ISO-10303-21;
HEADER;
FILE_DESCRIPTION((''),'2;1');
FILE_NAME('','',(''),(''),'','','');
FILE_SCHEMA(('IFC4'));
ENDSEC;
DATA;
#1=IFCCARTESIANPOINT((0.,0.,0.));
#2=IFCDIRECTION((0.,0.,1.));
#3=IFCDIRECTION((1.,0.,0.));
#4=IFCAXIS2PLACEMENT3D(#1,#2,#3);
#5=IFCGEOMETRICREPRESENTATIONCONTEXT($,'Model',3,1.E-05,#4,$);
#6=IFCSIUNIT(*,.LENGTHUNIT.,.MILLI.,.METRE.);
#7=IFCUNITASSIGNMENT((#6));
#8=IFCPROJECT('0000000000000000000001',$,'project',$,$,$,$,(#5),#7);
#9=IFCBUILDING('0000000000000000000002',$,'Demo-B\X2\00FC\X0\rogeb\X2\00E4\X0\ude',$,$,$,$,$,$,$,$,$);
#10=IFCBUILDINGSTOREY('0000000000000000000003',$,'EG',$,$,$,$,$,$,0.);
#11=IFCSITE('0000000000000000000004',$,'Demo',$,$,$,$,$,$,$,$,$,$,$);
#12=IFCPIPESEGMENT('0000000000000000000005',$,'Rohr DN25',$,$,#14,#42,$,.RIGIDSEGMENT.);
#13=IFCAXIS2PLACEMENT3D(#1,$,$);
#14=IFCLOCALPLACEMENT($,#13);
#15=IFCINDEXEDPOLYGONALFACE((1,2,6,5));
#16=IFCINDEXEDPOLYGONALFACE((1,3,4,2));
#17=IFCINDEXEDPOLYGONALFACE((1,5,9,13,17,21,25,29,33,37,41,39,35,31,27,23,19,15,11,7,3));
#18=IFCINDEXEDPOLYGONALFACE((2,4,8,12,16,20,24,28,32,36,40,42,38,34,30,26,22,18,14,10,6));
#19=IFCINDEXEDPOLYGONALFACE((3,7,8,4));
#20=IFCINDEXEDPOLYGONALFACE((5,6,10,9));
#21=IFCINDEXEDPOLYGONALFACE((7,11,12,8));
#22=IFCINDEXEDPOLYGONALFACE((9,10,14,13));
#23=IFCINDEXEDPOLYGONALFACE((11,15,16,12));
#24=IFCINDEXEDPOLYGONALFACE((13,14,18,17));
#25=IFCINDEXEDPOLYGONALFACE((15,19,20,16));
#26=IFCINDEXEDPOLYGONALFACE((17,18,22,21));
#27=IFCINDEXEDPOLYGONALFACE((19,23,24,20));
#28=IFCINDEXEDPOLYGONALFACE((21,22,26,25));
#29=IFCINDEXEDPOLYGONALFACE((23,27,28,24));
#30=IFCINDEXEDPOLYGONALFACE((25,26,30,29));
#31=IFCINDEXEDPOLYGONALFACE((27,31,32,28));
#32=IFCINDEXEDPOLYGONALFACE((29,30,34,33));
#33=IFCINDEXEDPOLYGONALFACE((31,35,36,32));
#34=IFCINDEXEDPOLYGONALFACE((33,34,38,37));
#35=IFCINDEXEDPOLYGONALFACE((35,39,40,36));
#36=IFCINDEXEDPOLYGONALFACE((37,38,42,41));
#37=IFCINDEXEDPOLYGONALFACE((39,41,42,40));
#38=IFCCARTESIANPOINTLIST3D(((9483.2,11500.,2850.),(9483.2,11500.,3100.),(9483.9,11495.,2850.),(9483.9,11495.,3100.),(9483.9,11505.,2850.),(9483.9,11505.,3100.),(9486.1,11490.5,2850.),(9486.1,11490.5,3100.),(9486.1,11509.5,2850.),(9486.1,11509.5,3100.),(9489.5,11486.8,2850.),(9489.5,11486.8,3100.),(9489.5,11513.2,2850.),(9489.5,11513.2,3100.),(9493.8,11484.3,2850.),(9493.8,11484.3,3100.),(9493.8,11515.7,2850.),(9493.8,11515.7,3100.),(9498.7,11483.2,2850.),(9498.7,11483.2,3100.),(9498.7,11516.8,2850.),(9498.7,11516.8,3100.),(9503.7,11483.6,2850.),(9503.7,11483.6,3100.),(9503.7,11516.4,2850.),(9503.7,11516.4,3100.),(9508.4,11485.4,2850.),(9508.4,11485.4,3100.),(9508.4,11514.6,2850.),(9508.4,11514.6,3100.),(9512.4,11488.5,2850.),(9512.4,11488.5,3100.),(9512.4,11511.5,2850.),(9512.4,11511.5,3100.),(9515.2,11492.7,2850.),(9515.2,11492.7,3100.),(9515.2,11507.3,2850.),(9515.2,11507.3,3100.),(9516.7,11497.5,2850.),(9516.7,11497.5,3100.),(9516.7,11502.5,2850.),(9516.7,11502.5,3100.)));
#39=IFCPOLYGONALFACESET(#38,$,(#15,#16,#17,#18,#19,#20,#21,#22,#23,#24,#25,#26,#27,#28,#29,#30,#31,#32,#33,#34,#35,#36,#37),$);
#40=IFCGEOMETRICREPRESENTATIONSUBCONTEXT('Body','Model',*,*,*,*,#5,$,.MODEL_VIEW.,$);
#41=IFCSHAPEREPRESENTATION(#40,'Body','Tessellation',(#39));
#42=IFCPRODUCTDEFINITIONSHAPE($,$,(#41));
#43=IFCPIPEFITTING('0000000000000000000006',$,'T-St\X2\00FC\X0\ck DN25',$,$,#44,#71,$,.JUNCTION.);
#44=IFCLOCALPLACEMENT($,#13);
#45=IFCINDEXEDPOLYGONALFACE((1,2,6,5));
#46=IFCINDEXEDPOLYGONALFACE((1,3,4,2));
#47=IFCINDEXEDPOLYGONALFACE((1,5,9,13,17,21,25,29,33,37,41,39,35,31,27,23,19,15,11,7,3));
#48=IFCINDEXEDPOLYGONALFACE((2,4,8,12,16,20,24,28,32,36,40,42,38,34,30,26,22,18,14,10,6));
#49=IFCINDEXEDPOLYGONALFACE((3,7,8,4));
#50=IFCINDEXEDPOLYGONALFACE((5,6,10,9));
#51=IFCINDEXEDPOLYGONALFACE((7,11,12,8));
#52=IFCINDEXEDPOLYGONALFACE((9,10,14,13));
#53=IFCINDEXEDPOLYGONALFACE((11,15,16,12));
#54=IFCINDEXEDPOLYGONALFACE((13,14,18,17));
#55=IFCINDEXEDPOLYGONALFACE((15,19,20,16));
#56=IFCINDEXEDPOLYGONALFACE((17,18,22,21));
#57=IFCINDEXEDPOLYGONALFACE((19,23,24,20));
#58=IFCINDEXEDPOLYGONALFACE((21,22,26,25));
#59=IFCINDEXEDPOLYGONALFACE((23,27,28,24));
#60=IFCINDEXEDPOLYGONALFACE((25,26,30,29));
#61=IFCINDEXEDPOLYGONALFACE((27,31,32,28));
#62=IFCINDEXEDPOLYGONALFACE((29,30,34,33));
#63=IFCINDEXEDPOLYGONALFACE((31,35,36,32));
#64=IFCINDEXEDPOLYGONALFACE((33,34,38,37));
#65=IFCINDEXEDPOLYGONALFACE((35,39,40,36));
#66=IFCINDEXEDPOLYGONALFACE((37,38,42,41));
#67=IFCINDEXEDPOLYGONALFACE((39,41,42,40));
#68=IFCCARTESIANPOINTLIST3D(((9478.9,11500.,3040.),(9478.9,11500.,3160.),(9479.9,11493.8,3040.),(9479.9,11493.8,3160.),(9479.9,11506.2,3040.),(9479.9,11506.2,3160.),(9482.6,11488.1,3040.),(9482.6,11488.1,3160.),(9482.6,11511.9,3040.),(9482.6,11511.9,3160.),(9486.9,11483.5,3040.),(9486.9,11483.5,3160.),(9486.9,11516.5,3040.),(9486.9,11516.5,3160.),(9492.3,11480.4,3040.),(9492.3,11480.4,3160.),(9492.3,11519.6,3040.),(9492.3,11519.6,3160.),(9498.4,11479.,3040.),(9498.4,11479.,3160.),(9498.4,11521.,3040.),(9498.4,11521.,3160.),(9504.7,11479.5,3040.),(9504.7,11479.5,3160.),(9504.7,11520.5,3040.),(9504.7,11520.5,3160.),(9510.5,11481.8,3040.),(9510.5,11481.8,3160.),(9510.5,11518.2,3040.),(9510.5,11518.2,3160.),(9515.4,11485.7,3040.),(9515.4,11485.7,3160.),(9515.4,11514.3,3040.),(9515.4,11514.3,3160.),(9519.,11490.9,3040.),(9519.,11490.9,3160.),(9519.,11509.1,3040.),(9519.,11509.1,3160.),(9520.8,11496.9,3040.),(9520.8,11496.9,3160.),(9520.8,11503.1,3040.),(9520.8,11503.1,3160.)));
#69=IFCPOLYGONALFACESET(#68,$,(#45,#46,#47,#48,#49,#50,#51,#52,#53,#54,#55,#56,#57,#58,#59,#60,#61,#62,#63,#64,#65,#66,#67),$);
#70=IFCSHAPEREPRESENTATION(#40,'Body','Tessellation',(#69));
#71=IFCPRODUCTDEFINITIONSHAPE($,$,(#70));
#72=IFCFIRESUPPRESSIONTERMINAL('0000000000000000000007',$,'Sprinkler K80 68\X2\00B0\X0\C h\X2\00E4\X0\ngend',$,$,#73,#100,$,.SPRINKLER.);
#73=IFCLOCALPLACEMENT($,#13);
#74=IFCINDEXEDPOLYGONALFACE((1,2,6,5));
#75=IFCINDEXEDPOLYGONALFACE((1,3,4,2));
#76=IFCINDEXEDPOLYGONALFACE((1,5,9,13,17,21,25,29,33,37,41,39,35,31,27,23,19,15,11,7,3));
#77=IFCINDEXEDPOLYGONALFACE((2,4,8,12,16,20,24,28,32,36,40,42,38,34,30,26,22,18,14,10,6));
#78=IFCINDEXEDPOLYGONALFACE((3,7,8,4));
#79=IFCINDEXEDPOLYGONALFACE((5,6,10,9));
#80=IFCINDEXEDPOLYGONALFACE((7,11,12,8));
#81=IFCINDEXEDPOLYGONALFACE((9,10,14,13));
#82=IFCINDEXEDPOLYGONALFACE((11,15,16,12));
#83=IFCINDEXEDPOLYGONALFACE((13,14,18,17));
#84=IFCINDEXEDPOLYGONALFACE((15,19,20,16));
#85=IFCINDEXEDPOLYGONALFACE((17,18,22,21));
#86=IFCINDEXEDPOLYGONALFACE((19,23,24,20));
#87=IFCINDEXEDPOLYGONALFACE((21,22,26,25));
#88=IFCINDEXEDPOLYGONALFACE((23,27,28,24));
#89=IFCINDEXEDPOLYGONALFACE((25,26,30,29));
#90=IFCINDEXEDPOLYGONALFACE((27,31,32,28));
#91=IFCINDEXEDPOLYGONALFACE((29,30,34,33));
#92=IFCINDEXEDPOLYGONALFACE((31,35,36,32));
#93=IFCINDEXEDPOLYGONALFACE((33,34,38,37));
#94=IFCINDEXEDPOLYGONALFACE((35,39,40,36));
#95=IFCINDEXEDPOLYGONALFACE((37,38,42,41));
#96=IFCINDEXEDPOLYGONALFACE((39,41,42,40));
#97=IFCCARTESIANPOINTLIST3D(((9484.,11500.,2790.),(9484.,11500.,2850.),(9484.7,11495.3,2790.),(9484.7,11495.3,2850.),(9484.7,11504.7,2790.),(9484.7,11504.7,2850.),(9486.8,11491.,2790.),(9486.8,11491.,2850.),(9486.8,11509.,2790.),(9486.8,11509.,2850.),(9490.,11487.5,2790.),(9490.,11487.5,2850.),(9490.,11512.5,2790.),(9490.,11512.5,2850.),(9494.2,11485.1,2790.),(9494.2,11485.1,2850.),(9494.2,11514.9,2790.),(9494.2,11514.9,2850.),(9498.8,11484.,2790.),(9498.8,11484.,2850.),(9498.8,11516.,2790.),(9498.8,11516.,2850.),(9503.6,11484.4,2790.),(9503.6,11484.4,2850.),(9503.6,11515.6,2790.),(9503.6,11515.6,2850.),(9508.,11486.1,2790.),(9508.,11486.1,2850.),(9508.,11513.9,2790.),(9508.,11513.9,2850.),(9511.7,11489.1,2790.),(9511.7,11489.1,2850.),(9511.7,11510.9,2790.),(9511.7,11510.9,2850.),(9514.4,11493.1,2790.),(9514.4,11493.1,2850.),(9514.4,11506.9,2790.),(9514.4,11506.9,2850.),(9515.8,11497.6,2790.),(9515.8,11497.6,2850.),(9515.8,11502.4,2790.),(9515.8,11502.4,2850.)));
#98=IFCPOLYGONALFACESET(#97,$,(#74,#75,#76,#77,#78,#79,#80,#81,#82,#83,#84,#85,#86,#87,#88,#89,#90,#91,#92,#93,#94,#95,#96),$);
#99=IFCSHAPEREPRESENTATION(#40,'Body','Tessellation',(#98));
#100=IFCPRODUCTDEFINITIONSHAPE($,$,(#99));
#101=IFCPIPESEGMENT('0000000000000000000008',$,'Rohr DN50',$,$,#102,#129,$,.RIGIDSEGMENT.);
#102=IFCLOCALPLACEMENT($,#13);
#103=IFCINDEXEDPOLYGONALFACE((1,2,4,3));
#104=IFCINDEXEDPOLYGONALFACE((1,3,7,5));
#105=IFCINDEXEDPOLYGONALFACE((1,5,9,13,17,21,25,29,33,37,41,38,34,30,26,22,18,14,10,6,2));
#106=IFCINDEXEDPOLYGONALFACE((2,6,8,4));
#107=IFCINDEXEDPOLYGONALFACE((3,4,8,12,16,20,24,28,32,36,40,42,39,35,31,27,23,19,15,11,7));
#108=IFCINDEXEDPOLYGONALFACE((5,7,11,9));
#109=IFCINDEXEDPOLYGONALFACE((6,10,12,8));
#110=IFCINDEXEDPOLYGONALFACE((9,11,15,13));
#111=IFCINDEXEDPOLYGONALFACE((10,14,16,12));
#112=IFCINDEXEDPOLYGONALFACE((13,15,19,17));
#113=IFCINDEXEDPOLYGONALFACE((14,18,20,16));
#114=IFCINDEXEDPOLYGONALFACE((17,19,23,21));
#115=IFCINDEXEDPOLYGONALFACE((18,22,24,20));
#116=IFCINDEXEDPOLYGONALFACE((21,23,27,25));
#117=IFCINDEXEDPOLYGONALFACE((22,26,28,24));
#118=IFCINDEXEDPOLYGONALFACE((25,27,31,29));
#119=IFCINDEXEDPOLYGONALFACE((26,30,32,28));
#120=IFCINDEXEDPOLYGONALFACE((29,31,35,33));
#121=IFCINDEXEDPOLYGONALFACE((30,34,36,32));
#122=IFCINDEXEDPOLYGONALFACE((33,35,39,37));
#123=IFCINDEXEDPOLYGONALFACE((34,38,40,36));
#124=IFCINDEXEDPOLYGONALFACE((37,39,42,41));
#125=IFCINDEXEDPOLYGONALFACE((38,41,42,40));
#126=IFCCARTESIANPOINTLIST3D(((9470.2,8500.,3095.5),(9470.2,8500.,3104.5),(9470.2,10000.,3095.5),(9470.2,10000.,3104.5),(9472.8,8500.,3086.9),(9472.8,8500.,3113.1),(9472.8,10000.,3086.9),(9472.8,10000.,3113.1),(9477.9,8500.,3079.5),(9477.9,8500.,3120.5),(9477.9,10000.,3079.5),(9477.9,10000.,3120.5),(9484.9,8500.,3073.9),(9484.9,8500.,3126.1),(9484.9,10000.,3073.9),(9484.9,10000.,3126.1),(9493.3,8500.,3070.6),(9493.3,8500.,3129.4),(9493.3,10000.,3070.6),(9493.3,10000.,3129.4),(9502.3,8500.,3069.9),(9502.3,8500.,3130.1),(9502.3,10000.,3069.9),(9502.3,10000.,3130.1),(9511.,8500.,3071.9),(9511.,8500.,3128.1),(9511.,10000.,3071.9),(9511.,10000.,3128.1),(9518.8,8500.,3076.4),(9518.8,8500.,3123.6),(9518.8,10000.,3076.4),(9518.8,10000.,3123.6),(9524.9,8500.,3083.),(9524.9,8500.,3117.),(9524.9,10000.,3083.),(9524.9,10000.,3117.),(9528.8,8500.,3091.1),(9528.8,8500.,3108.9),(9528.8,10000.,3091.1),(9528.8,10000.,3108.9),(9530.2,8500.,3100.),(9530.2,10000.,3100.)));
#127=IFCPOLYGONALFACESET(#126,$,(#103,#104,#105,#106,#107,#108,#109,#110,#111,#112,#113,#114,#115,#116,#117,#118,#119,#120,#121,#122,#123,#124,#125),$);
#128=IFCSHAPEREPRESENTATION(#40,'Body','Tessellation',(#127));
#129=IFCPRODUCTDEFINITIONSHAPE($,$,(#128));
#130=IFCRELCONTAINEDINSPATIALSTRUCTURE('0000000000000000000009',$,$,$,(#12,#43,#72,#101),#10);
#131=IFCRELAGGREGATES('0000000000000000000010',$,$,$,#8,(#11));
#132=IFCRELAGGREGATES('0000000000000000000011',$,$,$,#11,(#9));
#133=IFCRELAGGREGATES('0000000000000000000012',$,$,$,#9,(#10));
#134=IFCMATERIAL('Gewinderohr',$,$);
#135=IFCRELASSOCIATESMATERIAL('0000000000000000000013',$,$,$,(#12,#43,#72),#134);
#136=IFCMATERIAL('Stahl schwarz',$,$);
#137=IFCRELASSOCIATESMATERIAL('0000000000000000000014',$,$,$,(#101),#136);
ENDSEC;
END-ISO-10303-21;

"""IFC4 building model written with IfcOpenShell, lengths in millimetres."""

from ifc_helpers import new_model, si_unit, frame, origin_with_axes, place, context, subcontext, project, spatial, circle, extrude, material, element, save


model = new_model("IFC4")

# Units and contexts
model_context = context("Model", 3, precision=1e-05, world=origin_with_axes())
body_context = subcontext(model_context, "Body", "Model", "MODEL_VIEW")
ifc_project = project(units=[si_unit("LENGTHUNIT", "METRE", prefix="MILLI")], contexts=[model_context])

# Site, building, storey
site = spatial("IfcSite", under=ifc_project, Name="Demo")
building = spatial("IfcBuilding", under=site, Name="Demo-Bürogebäude")
storey = spatial("IfcBuildingStorey", under=building, Name="EG", Elevation=0.0)

# Shared definitions
ifc_material_1 = material(Name="Stahl schwarz")

# Shared definitions
ifc_material_2 = material(Name="Gewinderohr")

# Pipe segment
pipe_segment_1_placement = place(None, frame((9500.0, 11500.0, 3100.0), z_axis=(0.0, 0.0, -1.0), x_axis=(-1.0, 0.0, 0.0)))
element("IfcPipeSegment", 1, at=pipe_segment_1_placement, inside=storey, material=ifc_material_2, Name="Rohr DN25", PredefinedType="RIGIDSEGMENT", context=body_context, shape_type="SweptSolid", body=[
    extrude(circle(Radius=16.9), origin_with_axes(), (0.0, 0.0, 1.0), 250.0),
])

# Pipe fitting
pipe_fitting_1_placement = place(None, frame((9500.0, 11500.0, 3160.0), z_axis=(0.0, 0.0, -1.0), x_axis=(-1.0, 0.0, 0.0)))
element("IfcPipeFitting", 2, at=pipe_fitting_1_placement, inside=storey, material=ifc_material_2, Name="T-Stück DN25", PredefinedType="JUNCTION", context=body_context, shape_type="SweptSolid", body=[
    extrude(circle(Radius=21.1), origin_with_axes(), (0.0, 0.0, 1.0), 120.0),
])

# Fire suppression terminal
fire_suppression_terminal_1_placement = place(None, frame((9500.0, 11500.0, 2850.0), z_axis=(0.0, 0.0, -1.0), x_axis=(-1.0, 0.0, 0.0)))
element("IfcFireSuppressionTerminal", 3, at=fire_suppression_terminal_1_placement, inside=storey, material=ifc_material_2, Name="Sprinkler K80 68°C hängend", PredefinedType="SPRINKLER", context=body_context, shape_type="SweptSolid", body=[
    extrude(circle(Radius=16.0), origin_with_axes(), (0.0, 0.0, 1.0), 60.0),
])

# Pipe segment
pipe_segment_2_placement = place(None, frame((9500.0, 10000.0, 3100.0), z_axis=(0.0, -1.0, 0.0), x_axis=(1.0, 0.0, 0.0)))
element("IfcPipeSegment", 4, at=pipe_segment_2_placement, inside=storey, material=ifc_material_1, Name="Rohr DN50", PredefinedType="RIGIDSEGMENT", context=body_context, shape_type="SweptSolid", body=[
    extrude(circle(Radius=30.1), origin_with_axes(), (0.0, 0.0, 1.0), 1500.0),
])

save(model, "model.ifc")
